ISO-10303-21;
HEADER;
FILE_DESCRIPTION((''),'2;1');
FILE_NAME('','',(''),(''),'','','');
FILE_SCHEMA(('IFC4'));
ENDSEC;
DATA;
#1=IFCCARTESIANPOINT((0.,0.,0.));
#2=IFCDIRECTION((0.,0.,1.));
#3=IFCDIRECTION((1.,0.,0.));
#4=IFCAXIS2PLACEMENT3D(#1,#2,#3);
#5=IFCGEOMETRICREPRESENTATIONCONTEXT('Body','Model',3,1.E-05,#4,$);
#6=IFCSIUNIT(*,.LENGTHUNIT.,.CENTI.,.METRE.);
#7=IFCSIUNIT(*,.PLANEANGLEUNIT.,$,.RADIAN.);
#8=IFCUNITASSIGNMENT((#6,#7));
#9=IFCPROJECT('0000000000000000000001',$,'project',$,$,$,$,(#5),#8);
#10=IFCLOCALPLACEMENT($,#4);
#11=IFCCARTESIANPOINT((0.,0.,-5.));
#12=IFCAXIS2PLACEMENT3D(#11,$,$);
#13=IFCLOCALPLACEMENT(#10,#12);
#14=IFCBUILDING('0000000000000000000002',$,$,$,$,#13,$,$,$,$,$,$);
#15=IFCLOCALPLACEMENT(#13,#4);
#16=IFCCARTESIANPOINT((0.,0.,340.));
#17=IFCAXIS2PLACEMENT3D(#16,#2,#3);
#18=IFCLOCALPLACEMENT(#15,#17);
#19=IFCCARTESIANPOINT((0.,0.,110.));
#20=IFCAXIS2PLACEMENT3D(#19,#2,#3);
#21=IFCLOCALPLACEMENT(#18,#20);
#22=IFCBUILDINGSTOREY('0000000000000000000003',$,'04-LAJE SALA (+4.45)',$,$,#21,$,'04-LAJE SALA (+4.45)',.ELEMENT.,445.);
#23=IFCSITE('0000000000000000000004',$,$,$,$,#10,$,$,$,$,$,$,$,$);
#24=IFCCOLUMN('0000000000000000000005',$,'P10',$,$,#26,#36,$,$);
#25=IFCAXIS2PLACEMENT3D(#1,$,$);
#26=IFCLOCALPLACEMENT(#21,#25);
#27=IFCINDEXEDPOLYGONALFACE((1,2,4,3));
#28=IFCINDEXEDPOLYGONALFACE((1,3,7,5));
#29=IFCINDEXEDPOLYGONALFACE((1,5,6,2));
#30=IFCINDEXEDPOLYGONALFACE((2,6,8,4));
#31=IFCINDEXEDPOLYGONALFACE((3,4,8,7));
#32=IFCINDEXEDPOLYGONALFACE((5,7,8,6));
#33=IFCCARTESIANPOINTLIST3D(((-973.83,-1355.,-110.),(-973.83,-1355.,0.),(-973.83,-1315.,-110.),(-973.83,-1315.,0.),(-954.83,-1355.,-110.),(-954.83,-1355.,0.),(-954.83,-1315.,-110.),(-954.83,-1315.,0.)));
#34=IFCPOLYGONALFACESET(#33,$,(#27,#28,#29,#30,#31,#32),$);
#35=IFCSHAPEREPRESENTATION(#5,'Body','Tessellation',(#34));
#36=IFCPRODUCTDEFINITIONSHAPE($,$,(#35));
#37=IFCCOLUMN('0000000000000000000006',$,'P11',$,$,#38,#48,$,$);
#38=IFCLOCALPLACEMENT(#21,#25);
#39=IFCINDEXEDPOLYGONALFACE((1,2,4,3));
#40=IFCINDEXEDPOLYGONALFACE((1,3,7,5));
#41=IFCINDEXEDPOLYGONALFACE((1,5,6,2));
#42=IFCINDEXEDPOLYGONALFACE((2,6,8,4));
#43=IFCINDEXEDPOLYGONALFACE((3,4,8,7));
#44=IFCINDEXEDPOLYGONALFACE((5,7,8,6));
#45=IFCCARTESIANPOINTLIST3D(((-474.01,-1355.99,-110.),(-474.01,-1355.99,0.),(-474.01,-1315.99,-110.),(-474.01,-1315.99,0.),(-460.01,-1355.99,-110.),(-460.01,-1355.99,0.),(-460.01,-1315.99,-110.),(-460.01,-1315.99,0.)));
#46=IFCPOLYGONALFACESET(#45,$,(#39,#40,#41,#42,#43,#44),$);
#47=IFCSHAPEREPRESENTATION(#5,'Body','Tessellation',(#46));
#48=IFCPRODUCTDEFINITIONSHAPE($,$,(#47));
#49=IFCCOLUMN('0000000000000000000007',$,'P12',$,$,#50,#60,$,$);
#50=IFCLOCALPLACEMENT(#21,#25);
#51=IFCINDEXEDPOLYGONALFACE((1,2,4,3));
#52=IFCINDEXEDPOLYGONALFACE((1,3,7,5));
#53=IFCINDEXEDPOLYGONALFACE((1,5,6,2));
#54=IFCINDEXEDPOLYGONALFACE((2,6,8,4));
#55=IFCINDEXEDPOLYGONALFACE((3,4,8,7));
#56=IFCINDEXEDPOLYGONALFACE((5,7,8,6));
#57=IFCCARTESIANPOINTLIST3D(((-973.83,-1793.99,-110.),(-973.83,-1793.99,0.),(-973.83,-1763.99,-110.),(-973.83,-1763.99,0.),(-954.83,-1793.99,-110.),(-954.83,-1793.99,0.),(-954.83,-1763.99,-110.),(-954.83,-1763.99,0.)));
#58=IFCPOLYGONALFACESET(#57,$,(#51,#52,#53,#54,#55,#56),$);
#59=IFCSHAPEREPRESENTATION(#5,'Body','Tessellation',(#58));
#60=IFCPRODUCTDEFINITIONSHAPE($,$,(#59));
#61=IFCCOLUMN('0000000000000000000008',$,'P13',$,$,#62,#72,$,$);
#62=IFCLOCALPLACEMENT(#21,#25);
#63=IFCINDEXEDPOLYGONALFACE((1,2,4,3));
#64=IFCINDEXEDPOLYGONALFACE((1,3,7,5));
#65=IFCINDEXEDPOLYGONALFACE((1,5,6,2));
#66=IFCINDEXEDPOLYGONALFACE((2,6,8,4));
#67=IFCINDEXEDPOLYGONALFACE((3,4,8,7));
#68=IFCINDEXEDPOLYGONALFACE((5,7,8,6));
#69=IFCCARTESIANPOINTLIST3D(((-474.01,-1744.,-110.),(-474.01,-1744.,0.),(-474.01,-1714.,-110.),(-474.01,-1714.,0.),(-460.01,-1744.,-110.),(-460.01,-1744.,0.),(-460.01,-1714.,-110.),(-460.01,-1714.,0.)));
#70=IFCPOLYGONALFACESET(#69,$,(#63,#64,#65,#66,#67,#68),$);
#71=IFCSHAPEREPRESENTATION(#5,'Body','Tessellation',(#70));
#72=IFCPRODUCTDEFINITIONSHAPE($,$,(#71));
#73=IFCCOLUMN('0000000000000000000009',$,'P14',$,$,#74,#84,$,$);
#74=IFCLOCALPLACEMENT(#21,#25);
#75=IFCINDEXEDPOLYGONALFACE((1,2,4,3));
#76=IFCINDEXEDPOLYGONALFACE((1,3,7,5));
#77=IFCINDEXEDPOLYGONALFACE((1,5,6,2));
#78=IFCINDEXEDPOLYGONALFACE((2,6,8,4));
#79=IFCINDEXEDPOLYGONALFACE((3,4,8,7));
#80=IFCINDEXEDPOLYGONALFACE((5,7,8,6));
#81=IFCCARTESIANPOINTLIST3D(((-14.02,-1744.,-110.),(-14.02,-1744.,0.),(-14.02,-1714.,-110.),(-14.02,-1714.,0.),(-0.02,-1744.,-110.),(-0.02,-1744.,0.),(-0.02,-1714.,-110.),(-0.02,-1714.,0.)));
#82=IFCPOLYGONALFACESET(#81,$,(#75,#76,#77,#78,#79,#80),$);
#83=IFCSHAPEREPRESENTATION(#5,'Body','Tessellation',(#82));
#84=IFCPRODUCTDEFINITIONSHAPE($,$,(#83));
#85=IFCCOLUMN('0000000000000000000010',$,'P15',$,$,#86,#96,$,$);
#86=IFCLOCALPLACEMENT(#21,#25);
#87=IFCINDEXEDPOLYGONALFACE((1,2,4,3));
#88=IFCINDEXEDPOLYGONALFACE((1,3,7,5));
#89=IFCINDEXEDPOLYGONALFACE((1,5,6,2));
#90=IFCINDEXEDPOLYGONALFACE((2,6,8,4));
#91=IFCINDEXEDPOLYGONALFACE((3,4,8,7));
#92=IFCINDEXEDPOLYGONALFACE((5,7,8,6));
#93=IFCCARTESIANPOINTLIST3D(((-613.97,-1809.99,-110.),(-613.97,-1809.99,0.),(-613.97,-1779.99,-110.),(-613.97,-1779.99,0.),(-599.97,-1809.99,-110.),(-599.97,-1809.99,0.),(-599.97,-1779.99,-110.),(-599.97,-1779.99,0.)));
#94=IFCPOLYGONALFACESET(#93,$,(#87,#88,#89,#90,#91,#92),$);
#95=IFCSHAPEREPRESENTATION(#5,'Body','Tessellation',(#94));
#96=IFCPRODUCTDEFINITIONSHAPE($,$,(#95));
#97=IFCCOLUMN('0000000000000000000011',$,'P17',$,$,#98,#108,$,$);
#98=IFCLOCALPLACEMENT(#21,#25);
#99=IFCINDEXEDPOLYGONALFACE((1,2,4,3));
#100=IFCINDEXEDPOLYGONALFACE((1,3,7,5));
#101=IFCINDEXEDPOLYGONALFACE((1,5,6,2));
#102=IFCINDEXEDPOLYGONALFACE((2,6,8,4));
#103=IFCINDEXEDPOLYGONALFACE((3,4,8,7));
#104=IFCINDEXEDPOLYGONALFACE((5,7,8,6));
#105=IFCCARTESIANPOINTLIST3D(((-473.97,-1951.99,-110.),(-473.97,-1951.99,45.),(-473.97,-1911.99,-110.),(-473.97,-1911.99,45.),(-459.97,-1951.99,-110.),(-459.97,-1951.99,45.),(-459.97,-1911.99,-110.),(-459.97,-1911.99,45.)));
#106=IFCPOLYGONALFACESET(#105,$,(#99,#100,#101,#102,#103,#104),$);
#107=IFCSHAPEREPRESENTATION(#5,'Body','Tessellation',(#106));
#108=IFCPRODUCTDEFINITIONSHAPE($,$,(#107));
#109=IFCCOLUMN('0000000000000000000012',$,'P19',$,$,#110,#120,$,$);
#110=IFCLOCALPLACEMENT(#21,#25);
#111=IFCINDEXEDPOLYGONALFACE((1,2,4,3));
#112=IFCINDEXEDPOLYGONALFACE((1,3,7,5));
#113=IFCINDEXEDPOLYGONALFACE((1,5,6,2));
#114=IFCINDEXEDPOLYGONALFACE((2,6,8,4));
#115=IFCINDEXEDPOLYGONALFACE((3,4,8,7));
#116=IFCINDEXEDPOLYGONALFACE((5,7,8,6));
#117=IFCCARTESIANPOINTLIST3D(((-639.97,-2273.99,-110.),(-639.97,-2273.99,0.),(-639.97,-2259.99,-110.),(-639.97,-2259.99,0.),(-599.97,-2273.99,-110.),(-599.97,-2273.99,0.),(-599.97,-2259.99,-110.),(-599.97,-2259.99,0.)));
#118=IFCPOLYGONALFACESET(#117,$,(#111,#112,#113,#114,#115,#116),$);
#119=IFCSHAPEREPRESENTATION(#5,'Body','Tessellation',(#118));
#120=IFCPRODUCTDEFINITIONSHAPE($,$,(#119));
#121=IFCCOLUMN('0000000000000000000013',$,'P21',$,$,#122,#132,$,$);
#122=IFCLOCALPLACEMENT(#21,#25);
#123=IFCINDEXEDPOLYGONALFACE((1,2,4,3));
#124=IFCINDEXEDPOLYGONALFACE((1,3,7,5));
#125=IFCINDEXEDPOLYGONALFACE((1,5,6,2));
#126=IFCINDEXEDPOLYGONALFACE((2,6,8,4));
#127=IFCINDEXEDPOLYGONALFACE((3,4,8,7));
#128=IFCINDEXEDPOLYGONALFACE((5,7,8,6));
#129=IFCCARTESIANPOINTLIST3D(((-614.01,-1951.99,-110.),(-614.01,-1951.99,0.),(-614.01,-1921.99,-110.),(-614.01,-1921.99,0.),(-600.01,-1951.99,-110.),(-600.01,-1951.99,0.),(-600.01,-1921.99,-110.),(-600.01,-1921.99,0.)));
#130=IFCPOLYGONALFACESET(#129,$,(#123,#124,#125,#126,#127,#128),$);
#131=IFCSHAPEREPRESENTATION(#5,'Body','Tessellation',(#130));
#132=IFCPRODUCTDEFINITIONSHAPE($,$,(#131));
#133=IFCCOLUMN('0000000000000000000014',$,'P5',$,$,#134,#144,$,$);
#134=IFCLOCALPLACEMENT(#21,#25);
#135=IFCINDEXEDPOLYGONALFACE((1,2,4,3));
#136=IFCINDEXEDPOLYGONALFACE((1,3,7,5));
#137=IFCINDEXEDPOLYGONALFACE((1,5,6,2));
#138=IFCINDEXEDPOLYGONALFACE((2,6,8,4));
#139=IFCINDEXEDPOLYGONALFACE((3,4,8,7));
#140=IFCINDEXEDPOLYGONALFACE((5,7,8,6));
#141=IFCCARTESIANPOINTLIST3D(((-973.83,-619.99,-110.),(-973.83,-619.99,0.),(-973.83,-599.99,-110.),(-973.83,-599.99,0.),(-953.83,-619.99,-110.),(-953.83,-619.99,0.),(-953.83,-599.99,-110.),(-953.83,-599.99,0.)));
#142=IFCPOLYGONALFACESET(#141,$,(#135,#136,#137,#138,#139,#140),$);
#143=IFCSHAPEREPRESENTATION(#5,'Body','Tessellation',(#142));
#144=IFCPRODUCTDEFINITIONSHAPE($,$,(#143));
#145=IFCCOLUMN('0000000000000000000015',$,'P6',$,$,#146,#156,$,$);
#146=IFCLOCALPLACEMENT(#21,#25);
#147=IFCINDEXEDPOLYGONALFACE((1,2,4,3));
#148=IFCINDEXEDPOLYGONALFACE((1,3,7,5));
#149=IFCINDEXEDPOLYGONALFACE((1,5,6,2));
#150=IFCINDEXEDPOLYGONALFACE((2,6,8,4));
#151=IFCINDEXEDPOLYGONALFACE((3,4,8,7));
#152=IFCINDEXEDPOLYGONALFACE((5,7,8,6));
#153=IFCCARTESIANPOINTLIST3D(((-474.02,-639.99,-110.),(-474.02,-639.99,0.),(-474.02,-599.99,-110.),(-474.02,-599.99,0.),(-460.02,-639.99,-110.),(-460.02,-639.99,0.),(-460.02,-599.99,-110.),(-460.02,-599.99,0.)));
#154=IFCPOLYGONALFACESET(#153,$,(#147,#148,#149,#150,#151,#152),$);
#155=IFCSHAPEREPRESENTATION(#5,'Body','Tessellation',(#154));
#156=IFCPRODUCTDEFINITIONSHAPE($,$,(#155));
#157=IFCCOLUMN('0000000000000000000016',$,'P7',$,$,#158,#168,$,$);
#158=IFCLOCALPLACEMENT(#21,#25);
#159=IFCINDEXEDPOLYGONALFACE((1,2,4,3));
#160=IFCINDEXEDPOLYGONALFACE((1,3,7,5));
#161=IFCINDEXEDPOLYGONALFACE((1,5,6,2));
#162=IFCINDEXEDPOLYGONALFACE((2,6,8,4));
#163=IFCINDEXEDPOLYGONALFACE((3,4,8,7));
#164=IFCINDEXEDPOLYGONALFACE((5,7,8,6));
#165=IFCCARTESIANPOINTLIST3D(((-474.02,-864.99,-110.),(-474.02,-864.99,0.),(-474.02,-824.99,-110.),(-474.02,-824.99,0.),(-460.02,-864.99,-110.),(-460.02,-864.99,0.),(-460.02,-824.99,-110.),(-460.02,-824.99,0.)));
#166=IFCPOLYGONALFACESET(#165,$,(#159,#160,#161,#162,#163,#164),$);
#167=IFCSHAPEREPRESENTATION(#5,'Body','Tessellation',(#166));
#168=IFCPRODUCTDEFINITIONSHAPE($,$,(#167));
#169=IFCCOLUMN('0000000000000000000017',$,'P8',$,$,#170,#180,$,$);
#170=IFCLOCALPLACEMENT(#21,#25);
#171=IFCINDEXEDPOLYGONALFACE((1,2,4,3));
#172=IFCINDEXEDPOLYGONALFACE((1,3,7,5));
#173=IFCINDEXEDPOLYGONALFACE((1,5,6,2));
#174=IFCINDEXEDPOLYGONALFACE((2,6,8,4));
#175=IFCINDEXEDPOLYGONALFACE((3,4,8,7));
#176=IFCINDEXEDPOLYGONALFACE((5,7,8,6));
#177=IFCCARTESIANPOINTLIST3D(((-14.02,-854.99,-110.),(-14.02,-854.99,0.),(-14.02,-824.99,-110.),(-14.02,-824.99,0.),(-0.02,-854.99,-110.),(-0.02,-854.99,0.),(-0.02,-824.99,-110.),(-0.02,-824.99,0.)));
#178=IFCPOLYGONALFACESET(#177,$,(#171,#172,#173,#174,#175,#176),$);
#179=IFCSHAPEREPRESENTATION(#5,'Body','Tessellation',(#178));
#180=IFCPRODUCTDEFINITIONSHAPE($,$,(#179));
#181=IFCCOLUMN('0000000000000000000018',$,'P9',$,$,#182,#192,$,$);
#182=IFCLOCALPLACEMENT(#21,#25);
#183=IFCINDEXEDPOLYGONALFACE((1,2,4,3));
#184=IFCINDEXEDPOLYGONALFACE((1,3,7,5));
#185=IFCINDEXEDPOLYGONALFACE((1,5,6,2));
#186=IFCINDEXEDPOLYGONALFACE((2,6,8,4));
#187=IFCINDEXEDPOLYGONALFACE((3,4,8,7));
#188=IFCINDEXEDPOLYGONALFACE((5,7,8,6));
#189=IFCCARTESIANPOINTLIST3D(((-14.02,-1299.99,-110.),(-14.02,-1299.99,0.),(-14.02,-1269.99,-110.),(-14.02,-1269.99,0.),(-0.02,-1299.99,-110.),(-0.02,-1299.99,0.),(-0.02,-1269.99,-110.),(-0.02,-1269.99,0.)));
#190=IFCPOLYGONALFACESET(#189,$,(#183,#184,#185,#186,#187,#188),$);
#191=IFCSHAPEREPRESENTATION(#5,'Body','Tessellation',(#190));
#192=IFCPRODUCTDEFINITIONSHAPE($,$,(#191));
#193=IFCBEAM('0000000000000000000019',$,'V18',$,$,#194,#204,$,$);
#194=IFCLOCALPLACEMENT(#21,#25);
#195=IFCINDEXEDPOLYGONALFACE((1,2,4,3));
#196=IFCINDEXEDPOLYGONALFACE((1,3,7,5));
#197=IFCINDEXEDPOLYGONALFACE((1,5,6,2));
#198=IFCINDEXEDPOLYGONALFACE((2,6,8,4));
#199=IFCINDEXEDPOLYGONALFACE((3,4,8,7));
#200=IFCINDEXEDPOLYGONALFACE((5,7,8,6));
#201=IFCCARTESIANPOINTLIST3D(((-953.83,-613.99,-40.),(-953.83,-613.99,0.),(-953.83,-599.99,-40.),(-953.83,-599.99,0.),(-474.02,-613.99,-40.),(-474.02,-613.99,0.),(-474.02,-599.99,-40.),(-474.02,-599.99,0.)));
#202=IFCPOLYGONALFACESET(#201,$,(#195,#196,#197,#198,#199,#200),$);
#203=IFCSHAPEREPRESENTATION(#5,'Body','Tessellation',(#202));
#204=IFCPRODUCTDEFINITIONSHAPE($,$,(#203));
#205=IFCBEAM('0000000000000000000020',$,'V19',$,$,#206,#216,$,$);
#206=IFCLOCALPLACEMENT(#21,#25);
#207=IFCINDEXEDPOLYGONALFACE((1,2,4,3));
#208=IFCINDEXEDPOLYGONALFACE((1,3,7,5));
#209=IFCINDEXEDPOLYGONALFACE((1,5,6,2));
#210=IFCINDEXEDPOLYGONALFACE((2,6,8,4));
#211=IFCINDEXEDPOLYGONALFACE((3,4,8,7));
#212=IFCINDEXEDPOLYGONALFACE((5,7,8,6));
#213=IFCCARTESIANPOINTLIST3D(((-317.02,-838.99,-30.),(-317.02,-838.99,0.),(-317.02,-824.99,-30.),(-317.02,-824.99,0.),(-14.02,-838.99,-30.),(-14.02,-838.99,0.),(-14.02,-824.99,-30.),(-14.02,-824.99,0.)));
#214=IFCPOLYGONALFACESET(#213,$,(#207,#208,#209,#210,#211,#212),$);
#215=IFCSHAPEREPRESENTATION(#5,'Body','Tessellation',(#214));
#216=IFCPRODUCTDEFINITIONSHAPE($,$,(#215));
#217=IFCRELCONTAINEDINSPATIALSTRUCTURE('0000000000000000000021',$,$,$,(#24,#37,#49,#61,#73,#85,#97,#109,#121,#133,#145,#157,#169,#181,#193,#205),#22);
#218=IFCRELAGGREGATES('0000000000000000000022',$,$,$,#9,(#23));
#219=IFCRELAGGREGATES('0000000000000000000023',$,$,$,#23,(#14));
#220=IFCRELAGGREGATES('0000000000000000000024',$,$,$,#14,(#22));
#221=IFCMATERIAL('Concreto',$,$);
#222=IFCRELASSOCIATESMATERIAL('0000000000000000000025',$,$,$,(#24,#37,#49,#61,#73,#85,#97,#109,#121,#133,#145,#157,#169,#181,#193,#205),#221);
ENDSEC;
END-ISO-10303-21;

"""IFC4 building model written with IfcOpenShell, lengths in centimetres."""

from ifc_helpers import new_model, si_unit, frame, origin_with_axes, origin_2d_with_axis, place, context, project, spatial, rectangle, extrude, material, element, save


model = new_model("IFC4")

# Units and contexts
model_context = context("Model", 3, precision=1e-05, world=origin_with_axes(), identifier="Body")
ifc_project = project(units=[si_unit("LENGTHUNIT", "METRE", prefix="CENTI"), si_unit("PLANEANGLEUNIT", "RADIAN")], contexts=[model_context])

# Site, building, storey
site_placement = place(None, origin_with_axes())
site = spatial("IfcSite", under=ifc_project, at=site_placement)
building_placement = place(site_placement, frame((0.0, 0.0, -5.0)))
building = spatial("IfcBuilding", under=site, at=building_placement)
placement_1 = place(building_placement, origin_with_axes())
placement_2 = place(placement_1, frame((0.0, 0.0, 340.0), z_axis=(0.0, 0.0, 1.0), x_axis=(1.0, 0.0, 0.0)))
storey_placement = place(placement_2, frame((0.0, 0.0, 110.0), z_axis=(0.0, 0.0, 1.0), x_axis=(1.0, 0.0, 0.0)))
storey = spatial("IfcBuildingStorey", under=building, at=storey_placement, Name="04-LAJE SALA (+4.45)", LongName="04-LAJE SALA (+4.45)", CompositionType="ELEMENT", Elevation=445.0)

# Columns
ifc_material_1 = material(Name="Concreto")
column_1_placement = place(storey_placement, frame((-964.33, -1335.0, 0.0), z_axis=(0.0, 0.0, 1.0), x_axis=(1.0, 0.0, 0.0)))
element("IfcColumn", 1, at=column_1_placement, inside=storey, material=ifc_material_1, Name="P10", context=model_context, shape_type="SolidModel", body=[
    extrude(rectangle(XDim=19.0, YDim=40.0, at=origin_2d_with_axis()), origin_with_axes(), (0.0, 0.0, -1.0), 110.0),
])
column_2_placement = place(storey_placement, frame((-467.01, -1335.99, 0.0), z_axis=(0.0, 0.0, 1.0), x_axis=(1.0, 0.0, 0.0)))
element("IfcColumn", 2, at=column_2_placement, inside=storey, material=ifc_material_1, Name="P11", context=model_context, shape_type="SolidModel", body=[
    extrude(rectangle(XDim=14.0, YDim=40.0, at=origin_2d_with_axis()), origin_with_axes(), (0.0, 0.0, -1.0), 110.0),
])
column_3_placement = place(storey_placement, frame((-964.33, -1778.99, 0.0), z_axis=(0.0, 0.0, 1.0), x_axis=(1.0, 0.0, 0.0)))
element("IfcColumn", 3, at=column_3_placement, inside=storey, material=ifc_material_1, Name="P12", context=model_context, shape_type="SolidModel", body=[
    extrude(rectangle(XDim=19.0, YDim=30.0, at=origin_2d_with_axis()), origin_with_axes(), (0.0, 0.0, -1.0), 110.0),
])
for number, where, z_axis, x_axis, name in (
    (4, (-467.01, -1729.0, 0.0), (0.0, 0.0, 1.0), (1.0, 0.0, 0.0), "P13"),
    (5, (-7.02, -1729.0, 0.0), (0.0, 0.0, 1.0), (1.0, 0.0, 0.0), "P14"),
    (6, (-606.97, -1794.99, 0.0), (0.0, 0.0, 1.0), (1.0, 0.0, 0.0), "P15"),
):
    element("IfcColumn", number, at=place(storey_placement, frame(where, z_axis=z_axis, x_axis=x_axis)), inside=storey, material=ifc_material_1, Name=name, context=model_context, shape_type="SolidModel", body=[
        extrude(rectangle(XDim=14.0, YDim=30.0, at=origin_2d_with_axis()), origin_with_axes(), (0.0, 0.0, -1.0), 110.0),
    ])
column_4_placement = place(storey_placement, frame((-466.97, -1931.99, 45.0), z_axis=(0.0, 0.0, 1.0), x_axis=(1.0, 0.0, 0.0)))
element("IfcColumn", 7, at=column_4_placement, inside=storey, material=ifc_material_1, Name="P17", context=model_context, shape_type="SolidModel", body=[
    extrude(rectangle(XDim=14.0, YDim=40.0, at=origin_2d_with_axis()), origin_with_axes(), (0.0, 0.0, -1.0), 155.0),
])
column_5_placement = place(storey_placement, frame((-619.97, -2266.99, 0.0), z_axis=(0.0, 0.0, 1.0), x_axis=(1.0, 0.0, 0.0)))
element("IfcColumn", 8, at=column_5_placement, inside=storey, material=ifc_material_1, Name="P19", context=model_context, shape_type="SolidModel", body=[
    extrude(rectangle(XDim=14.0, YDim=40.0, at=origin_2d_with_axis()), frame((0.0, 0.0, 0.0), z_axis=(0.0, 0.0, 1.0), x_axis=(0.0, 1.0, 0.0)), (0.0, 0.0, -1.0), 110.0),
])
column_6_placement = place(storey_placement, frame((-607.01, -1936.99, 0.0), z_axis=(0.0, 0.0, 1.0), x_axis=(1.0, 0.0, 0.0)))
element("IfcColumn", 9, at=column_6_placement, inside=storey, material=ifc_material_1, Name="P21", context=model_context, shape_type="SolidModel", body=[
    extrude(rectangle(XDim=14.0, YDim=30.0, at=origin_2d_with_axis()), origin_with_axes(), (0.0, 0.0, -1.0), 110.0),
])
column_7_placement = place(storey_placement, frame((-963.83, -609.99, 0.0), z_axis=(0.0, 0.0, 1.0), x_axis=(1.0, 0.0, 0.0)))
element("IfcColumn", 10, at=column_7_placement, inside=storey, material=ifc_material_1, Name="P5", context=model_context, shape_type="SolidModel", body=[
    extrude(rectangle(XDim=20.0, YDim=20.0, at=origin_2d_with_axis()), origin_with_axes(), (0.0, 0.0, -1.0), 110.0),
])
for number, where, z_axis, x_axis, name in (
    (11, (-467.02, -619.99, 0.0), (0.0, 0.0, 1.0), (1.0, 0.0, 0.0), "P6"),
    (12, (-467.02, -844.99, 0.0), (0.0, 0.0, 1.0), (1.0, 0.0, 0.0), "P7"),
):
    element("IfcColumn", number, at=place(storey_placement, frame(where, z_axis=z_axis, x_axis=x_axis)), inside=storey, material=ifc_material_1, Name=name, context=model_context, shape_type="SolidModel", body=[
        extrude(rectangle(XDim=14.0, YDim=40.0, at=origin_2d_with_axis()), origin_with_axes(), (0.0, 0.0, -1.0), 110.0),
    ])
for number, where, z_axis, x_axis, name in (
    (13, (-7.02, -839.99, 0.0), (0.0, 0.0, 1.0), (1.0, 0.0, 0.0), "P8"),
    (14, (-7.02, -1284.99, 0.0), (0.0, 0.0, 1.0), (1.0, 0.0, 0.0), "P9"),
):
    element("IfcColumn", number, at=place(storey_placement, frame(where, z_axis=z_axis, x_axis=x_axis)), inside=storey, material=ifc_material_1, Name=name, context=model_context, shape_type="SolidModel", body=[
        extrude(rectangle(XDim=14.0, YDim=30.0, at=origin_2d_with_axis()), origin_with_axes(), (0.0, 0.0, -1.0), 110.0),
    ])

# Beams
beam_1_placement = place(storey_placement, frame((-713.92, -606.99, 0.0), z_axis=(0.0, 0.0, 1.0), x_axis=(1.0, 0.0, 0.0)))
element("IfcBeam", 15, at=beam_1_placement, inside=storey, material=ifc_material_1, Name="V18", context=model_context, shape_type="SolidModel", body=[
    extrude(rectangle(XDim=14.0, YDim=40.0, at=origin_2d_with_axis()), frame((-239.91, 0.0, -20.0), z_axis=(1.0, 0.0, 0.0), x_axis=(0.0, -1.0, 0.0)), (0.0, 0.0, 1.0), 479.81),
])
beam_2_placement = place(storey_placement, frame((-165.52, -831.99, 0.0), z_axis=(0.0, 0.0, 1.0), x_axis=(1.0, 0.0, 0.0)))
element("IfcBeam", 16, at=beam_2_placement, inside=storey, material=ifc_material_1, Name="V19", context=model_context, shape_type="SolidModel", body=[
    extrude(rectangle(XDim=14.0, YDim=30.0, at=origin_2d_with_axis()), frame((-151.5, 0.0, -15.0), z_axis=(1.0, 0.0, 0.0), x_axis=(0.0, -1.0, 0.0)), (0.0, 0.0, 1.0), 303.0),
])

save(model, "model.ifc")
